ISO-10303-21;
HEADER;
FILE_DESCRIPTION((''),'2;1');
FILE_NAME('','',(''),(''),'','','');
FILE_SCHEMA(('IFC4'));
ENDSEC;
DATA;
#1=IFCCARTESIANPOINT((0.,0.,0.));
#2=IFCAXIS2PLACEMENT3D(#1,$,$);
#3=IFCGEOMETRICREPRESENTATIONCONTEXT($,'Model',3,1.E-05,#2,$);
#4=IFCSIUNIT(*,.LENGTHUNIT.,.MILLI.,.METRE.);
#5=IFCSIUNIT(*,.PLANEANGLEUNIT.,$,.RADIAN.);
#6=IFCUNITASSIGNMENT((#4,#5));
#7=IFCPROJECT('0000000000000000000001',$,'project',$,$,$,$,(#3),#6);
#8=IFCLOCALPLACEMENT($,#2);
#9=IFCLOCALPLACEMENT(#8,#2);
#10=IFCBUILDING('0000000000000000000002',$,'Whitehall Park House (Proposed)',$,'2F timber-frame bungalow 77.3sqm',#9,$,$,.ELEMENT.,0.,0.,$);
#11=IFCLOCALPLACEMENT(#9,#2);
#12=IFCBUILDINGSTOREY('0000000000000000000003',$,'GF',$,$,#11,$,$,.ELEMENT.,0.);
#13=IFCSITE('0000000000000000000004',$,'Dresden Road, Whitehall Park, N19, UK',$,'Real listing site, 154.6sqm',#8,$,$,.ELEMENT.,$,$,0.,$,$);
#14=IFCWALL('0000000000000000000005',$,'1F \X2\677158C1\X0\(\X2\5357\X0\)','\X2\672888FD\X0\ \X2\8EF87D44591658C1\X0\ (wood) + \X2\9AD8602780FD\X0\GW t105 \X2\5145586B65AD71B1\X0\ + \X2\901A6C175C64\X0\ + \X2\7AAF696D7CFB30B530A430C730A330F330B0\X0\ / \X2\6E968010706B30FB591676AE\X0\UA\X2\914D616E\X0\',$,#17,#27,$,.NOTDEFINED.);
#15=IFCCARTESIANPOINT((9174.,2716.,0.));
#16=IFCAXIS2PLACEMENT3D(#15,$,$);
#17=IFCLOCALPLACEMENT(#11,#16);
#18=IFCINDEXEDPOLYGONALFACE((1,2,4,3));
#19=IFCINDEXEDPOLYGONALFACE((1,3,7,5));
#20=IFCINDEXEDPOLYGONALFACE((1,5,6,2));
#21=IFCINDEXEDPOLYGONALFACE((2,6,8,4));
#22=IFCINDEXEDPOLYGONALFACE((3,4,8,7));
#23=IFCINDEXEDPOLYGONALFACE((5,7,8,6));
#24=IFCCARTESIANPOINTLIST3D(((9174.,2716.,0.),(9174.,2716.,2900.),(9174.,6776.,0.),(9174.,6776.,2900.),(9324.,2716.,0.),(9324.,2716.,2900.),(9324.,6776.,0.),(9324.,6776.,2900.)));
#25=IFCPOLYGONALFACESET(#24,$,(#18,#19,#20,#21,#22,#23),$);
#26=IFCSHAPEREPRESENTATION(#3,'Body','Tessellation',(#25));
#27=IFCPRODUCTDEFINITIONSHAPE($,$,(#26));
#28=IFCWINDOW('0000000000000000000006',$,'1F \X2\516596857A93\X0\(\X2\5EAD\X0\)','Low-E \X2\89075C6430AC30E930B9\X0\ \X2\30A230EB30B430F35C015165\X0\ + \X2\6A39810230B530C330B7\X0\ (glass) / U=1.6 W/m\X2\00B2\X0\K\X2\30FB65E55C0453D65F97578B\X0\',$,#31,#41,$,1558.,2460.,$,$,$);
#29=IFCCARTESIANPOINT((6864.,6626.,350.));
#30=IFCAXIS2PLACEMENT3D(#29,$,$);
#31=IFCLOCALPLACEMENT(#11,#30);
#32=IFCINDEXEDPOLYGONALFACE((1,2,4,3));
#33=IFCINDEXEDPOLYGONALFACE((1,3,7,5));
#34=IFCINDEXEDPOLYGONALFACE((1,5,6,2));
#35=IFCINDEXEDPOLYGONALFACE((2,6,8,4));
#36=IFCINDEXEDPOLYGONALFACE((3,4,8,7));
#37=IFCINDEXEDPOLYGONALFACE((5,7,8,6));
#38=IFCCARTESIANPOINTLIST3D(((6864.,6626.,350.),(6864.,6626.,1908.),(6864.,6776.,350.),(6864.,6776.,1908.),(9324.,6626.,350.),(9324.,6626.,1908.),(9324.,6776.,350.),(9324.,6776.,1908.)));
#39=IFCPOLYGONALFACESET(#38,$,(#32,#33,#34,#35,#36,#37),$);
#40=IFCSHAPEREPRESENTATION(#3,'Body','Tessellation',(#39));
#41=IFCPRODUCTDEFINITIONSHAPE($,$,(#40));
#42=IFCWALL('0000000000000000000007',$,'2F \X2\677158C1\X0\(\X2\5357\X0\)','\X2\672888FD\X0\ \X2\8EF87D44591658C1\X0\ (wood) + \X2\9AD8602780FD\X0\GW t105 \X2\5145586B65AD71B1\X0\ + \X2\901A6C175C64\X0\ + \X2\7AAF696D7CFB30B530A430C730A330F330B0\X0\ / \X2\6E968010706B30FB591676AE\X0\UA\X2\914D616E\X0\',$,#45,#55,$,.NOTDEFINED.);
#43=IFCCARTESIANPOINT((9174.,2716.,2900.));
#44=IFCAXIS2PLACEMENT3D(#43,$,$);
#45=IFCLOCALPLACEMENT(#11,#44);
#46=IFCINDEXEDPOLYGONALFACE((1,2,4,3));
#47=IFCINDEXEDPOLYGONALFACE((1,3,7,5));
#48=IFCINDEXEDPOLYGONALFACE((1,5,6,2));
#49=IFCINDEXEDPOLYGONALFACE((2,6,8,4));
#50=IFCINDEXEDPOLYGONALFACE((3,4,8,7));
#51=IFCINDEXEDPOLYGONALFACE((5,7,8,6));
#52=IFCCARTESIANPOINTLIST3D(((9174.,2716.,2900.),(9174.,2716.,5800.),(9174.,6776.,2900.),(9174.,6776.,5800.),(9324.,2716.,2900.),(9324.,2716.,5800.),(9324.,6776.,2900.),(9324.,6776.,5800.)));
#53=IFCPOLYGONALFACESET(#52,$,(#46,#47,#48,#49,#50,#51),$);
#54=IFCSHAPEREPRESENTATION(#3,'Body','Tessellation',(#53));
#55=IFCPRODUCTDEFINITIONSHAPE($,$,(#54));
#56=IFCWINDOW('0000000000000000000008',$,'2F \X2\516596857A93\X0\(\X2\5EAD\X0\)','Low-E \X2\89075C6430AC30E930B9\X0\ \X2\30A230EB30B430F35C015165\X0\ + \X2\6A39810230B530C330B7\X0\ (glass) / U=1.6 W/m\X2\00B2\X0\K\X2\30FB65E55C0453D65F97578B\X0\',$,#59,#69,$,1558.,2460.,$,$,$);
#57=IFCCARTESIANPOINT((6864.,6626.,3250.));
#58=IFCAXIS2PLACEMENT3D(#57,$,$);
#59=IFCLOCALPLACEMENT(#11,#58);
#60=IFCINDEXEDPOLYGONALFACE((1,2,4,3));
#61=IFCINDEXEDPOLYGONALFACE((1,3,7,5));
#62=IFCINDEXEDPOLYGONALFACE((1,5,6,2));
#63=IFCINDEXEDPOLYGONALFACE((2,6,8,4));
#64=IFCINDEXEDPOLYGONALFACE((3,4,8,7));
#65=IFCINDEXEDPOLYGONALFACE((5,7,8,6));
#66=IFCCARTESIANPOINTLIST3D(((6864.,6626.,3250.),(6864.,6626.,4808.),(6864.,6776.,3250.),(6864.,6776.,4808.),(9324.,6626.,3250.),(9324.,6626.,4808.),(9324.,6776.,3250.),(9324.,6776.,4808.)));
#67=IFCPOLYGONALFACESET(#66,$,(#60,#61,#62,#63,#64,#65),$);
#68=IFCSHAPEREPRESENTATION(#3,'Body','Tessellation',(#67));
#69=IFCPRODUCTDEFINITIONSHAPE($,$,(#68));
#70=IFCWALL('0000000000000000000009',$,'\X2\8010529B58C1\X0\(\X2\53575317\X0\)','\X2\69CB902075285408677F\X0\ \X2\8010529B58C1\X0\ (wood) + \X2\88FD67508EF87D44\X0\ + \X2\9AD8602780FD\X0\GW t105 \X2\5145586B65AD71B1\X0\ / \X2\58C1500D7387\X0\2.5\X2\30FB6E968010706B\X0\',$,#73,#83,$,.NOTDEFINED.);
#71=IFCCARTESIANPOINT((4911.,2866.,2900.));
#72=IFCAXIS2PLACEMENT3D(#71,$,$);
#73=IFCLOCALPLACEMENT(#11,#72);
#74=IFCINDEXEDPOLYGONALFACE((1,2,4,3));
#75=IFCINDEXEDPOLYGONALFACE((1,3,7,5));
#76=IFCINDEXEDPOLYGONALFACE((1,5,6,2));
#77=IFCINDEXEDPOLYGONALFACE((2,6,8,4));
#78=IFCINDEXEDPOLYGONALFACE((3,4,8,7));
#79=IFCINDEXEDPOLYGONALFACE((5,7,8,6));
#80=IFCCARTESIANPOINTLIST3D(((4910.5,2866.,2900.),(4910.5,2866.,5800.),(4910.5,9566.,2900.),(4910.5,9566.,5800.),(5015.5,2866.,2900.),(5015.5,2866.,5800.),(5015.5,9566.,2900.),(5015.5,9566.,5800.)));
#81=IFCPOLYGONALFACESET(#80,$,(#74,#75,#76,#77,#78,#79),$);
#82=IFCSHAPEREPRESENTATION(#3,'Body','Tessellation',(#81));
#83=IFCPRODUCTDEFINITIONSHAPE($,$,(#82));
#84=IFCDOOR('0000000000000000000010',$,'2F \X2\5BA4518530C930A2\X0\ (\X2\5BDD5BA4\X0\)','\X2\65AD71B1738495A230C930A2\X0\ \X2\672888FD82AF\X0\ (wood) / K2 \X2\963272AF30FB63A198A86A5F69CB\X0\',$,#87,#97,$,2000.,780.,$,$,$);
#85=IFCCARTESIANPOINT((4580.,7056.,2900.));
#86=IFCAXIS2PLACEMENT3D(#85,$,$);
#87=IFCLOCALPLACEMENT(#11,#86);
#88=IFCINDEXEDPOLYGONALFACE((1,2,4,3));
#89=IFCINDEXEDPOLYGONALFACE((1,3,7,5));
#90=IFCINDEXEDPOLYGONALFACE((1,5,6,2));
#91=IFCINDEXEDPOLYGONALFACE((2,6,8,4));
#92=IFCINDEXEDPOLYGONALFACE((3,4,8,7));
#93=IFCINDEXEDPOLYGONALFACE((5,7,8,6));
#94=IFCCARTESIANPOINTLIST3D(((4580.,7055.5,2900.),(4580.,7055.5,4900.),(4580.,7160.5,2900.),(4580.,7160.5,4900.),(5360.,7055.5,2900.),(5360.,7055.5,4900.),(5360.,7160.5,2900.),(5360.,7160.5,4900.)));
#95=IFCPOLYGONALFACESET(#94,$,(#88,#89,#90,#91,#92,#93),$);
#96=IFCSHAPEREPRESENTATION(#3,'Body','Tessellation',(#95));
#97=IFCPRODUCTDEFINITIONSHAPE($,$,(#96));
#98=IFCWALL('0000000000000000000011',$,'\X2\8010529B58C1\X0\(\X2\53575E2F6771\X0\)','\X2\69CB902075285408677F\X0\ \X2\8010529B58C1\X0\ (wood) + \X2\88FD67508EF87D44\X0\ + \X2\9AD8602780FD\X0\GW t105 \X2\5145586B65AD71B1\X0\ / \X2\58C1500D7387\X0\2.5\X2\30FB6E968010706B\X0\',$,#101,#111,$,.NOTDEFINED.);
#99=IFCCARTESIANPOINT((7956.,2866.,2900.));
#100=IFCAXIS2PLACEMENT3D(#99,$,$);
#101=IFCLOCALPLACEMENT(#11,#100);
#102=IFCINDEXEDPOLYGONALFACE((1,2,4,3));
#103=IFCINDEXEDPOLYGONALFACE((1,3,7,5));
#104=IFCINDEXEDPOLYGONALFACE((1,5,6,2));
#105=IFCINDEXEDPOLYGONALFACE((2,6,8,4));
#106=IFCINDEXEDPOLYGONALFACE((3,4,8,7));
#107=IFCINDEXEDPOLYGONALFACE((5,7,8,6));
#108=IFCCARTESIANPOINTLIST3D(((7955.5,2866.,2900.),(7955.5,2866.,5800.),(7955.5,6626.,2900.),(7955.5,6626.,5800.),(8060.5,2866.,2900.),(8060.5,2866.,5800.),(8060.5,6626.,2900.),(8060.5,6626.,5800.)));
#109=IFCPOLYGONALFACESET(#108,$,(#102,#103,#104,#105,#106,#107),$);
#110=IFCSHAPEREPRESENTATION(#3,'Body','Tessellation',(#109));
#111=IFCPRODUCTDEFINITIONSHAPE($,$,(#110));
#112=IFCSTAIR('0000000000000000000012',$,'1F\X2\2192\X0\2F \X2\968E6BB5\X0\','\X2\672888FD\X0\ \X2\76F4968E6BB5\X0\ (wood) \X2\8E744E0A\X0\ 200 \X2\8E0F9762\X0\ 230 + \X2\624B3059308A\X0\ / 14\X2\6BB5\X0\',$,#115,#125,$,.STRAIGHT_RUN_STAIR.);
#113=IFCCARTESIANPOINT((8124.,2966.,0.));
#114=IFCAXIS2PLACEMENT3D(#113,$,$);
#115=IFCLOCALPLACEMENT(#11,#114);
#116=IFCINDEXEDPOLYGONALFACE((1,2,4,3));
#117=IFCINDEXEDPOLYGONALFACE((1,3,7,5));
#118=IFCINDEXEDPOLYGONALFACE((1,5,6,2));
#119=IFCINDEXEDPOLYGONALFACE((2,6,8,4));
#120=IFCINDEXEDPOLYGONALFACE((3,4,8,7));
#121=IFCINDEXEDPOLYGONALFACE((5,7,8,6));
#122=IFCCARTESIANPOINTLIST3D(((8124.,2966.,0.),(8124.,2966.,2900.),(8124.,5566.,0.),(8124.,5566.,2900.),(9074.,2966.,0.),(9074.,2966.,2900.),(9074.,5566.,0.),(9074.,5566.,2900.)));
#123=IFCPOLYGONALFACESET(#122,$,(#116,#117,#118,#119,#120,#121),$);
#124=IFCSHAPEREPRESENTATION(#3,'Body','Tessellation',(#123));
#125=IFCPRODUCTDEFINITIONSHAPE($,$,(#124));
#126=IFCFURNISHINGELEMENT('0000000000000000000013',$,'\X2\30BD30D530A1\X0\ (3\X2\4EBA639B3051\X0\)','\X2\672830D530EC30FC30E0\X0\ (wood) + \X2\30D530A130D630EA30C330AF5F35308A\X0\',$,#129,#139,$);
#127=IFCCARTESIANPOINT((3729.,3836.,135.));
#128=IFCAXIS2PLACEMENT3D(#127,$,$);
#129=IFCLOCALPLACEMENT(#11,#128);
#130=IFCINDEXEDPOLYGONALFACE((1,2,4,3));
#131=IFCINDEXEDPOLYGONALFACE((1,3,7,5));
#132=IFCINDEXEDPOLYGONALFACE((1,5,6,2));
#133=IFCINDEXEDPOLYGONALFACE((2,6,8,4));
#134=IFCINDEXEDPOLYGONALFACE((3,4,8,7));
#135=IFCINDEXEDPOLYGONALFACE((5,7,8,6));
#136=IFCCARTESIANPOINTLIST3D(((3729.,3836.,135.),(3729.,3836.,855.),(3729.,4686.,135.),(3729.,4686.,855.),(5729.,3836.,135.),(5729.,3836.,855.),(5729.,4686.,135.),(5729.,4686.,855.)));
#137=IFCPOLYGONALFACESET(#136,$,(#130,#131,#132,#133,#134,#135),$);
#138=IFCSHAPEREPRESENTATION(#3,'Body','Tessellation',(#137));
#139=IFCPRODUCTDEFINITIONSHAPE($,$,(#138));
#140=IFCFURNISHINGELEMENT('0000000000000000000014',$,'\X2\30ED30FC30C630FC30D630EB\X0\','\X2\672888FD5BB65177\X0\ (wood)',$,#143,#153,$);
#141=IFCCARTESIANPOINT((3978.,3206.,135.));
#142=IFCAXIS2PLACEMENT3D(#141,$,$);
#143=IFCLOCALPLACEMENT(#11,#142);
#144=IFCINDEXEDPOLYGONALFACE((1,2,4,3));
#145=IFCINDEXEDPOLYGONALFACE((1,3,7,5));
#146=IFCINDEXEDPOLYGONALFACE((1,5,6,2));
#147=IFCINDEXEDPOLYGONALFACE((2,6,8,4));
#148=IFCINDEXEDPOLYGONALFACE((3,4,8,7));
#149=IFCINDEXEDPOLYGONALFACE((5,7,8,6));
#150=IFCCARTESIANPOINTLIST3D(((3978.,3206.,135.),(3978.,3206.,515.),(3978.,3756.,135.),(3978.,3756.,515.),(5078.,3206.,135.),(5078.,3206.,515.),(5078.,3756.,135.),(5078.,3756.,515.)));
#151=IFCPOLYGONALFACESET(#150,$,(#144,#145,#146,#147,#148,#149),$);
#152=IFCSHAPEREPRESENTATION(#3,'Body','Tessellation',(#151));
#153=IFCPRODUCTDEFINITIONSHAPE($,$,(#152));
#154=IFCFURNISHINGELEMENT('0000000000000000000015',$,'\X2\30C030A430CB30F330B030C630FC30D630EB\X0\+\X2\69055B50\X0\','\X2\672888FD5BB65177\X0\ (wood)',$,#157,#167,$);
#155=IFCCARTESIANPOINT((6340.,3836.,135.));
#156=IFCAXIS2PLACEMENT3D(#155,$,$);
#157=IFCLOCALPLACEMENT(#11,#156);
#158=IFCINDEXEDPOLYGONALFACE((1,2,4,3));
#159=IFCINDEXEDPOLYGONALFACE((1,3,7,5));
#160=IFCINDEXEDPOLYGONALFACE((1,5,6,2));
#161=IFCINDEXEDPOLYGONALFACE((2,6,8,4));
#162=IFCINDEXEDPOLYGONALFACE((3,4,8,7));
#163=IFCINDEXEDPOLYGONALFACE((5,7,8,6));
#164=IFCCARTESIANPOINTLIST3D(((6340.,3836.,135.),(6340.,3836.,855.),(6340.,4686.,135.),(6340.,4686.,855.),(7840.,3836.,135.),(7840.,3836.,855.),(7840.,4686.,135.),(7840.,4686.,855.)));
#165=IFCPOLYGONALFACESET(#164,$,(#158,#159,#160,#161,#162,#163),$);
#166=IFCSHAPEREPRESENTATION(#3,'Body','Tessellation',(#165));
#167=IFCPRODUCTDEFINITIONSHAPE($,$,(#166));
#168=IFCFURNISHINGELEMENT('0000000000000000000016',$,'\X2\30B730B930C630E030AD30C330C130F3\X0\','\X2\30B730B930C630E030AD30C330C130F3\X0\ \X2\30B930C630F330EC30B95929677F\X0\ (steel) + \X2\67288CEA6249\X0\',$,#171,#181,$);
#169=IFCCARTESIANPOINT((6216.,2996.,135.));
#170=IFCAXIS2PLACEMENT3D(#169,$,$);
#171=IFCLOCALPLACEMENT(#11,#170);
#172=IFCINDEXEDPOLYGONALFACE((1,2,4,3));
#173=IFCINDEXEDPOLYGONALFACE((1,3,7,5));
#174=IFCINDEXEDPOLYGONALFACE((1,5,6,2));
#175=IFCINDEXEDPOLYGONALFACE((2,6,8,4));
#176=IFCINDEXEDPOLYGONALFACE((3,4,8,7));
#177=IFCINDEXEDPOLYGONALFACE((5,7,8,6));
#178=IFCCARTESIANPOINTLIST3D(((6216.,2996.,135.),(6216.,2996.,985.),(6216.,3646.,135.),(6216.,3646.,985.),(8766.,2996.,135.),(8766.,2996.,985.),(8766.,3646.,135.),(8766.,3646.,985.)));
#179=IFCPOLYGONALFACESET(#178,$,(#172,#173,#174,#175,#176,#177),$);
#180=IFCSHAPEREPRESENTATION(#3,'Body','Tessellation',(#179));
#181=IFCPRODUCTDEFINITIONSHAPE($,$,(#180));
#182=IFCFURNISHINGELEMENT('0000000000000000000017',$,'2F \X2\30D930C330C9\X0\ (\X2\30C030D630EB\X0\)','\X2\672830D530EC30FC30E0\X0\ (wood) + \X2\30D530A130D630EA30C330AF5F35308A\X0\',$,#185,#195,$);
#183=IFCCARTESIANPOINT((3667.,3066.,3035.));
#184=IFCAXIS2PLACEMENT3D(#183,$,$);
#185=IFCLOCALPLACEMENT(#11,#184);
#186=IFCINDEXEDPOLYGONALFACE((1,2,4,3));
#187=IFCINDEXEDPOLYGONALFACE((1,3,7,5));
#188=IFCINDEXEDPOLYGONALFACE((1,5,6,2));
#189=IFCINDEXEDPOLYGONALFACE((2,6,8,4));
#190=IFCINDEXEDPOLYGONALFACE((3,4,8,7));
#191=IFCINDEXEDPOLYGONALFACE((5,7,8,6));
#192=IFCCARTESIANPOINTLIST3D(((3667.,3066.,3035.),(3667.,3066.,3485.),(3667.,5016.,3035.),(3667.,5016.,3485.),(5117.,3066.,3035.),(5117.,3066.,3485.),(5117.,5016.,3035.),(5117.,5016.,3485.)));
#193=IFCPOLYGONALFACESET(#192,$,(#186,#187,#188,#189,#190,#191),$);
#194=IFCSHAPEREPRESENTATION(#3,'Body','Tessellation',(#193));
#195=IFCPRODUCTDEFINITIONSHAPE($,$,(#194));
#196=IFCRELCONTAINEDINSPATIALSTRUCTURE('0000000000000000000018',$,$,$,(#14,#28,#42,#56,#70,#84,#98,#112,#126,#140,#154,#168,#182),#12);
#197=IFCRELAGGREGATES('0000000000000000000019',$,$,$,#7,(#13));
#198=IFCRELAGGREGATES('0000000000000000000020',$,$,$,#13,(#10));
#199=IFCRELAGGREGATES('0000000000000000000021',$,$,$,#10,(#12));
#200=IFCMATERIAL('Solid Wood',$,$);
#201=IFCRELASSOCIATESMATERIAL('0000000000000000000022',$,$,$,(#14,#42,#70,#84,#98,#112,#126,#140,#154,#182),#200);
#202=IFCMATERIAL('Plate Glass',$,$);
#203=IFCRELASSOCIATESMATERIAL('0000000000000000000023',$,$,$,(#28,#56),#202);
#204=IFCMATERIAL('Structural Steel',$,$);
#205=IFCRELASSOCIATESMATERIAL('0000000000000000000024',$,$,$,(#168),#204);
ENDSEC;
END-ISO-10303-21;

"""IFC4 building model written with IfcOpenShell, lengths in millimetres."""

from ifc_helpers import new_model, si_unit, frame, frame_2d, origin, place, context, project, spatial, rectangle, extrude, material, element, fill, save


model = new_model("IFC4")

# Units and contexts
model_context = context("Model", 3, precision=1e-05, world=origin())
ifc_project = project(units=[si_unit("LENGTHUNIT", "METRE", prefix="MILLI"), si_unit("PLANEANGLEUNIT", "RADIAN")], contexts=[model_context])

# Site, building, storey
site_placement = place(None, origin())
site = spatial("IfcSite", under=ifc_project, at=site_placement, Name="Dresden Road, Whitehall Park, N19, UK", ObjectType="Real listing site, 154.6sqm", CompositionType="ELEMENT", RefElevation=0.0)
building_placement = place(site_placement, origin())
building = spatial("IfcBuilding", under=site, at=building_placement, Name="Whitehall Park House (Proposed)", ObjectType="2F timber-frame bungalow 77.3sqm", CompositionType="ELEMENT", ElevationOfRefHeight=0.0, ElevationOfTerrain=0.0)
storey_placement = place(building_placement, origin())
storey = spatial("IfcBuildingStorey", under=building, at=storey_placement, Name="GF", CompositionType="ELEMENT", Elevation=0.0)

# Wall, opening, window
ifc_material_1 = material(Name="Solid Wood")
wall_1_placement = place(storey_placement, frame((9174.0, 2716.0, 0.0)))
wall_1 = element("IfcWall", 1, at=wall_1_placement, inside=storey, material=ifc_material_1, Name="1F 東壁(南)", Description="木製 軸組外壁 (wood) + 高性能GW t105 充填断熱 + 通気層 + 窯業系サイディング / 準耐火・外皮UA配慮", PredefinedType="NOTDEFINED", context=model_context, shape_type="SweptSolid", body=[
    extrude(rectangle(XDim=150.0, YDim=4060.0, at=frame_2d((75.0, 2030.0))), frame((9174.0, 2716.0, 0.0)), (0.0, 0.0, 1.0), 2900.0),
])
opening_1_placement = place(storey_placement, frame((6864.0, 6626.0, 350.0)))
opening_1 = element("IfcOpeningElement", 2, at=opening_1_placement, cuts=wall_1, PredefinedType="NOTDEFINED", context=model_context, shape_type="SweptSolid", body=[
    extrude(rectangle(XDim=2460.0, YDim=150.0, at=frame_2d((1230.0, 75.0))), frame((6864.0, 6626.0, 350.0)), (0.0, 0.0, 1.0), 1558.0),
])
ifc_material_2 = material(Name="Plate Glass")
window_1_placement = place(storey_placement, frame((6864.0, 6626.0, 350.0)))
window_1 = element("IfcWindow", 3, at=window_1_placement, inside=storey, material=ifc_material_2, Name="1F 入隅窓(庭)", Description="Low-E 複層ガラス アルゴン封入 + 樹脂サッシ (glass) / U=1.6 W/m²K・日射取得型", OverallHeight=1558.0, OverallWidth=2460.0, context=model_context, shape_type="SweptSolid", body=[
    extrude(rectangle(XDim=2460.0, YDim=150.0, at=frame_2d((1230.0, 75.0))), frame((6864.0, 6626.0, 350.0)), (0.0, 0.0, 1.0), 1558.0),
])
fill(opening_1, window_1)

# Wall, opening, window
wall_2_placement = place(storey_placement, frame((9174.0, 2716.0, 2900.0)))
wall_2 = element("IfcWall", 4, at=wall_2_placement, inside=storey, material=ifc_material_1, Name="2F 東壁(南)", Description="木製 軸組外壁 (wood) + 高性能GW t105 充填断熱 + 通気層 + 窯業系サイディング / 準耐火・外皮UA配慮", PredefinedType="NOTDEFINED", context=model_context, shape_type="SweptSolid", body=[
    extrude(rectangle(XDim=150.0, YDim=4060.0, at=frame_2d((75.0, 2030.0))), frame((9174.0, 2716.0, 2900.0)), (0.0, 0.0, 1.0), 2900.0),
])
opening_2_placement = place(storey_placement, frame((6864.0, 6626.0, 3250.0)))
opening_2 = element("IfcOpeningElement", 5, at=opening_2_placement, cuts=wall_2, PredefinedType="NOTDEFINED", context=model_context, shape_type="SweptSolid", body=[
    extrude(rectangle(XDim=2460.0, YDim=150.0, at=frame_2d((1230.0, 75.0))), frame((6864.0, 6626.0, 3250.0)), (0.0, 0.0, 1.0), 1558.0),
])
window_2_placement = place(storey_placement, frame((6864.0, 6626.0, 3250.0)))
window_2 = element("IfcWindow", 6, at=window_2_placement, inside=storey, material=ifc_material_2, Name="2F 入隅窓(庭)", Description="Low-E 複層ガラス アルゴン封入 + 樹脂サッシ (glass) / U=1.6 W/m²K・日射取得型", OverallHeight=1558.0, OverallWidth=2460.0, context=model_context, shape_type="SweptSolid", body=[
    extrude(rectangle(XDim=2460.0, YDim=150.0, at=frame_2d((1230.0, 75.0))), frame((6864.0, 6626.0, 3250.0)), (0.0, 0.0, 1.0), 1558.0),
])
fill(opening_2, window_2)

# Wall, opening, door
wall_3_placement = place(storey_placement, frame((4911.0, 2866.0, 2900.0)))
wall_3 = element("IfcWall", 7, at=wall_3_placement, inside=storey, material=ifc_material_1, Name="耐力壁(南北)", Description="構造用合板 耐力壁 (wood) + 製材軸組 + 高性能GW t105 充填断熱 / 壁倍率2.5・準耐火", PredefinedType="NOTDEFINED", context=model_context, shape_type="SweptSolid", body=[
    extrude(rectangle(XDim=105.0, YDim=6700.0, at=frame_2d((52.0, 3350.0))), frame((4911.0, 2866.0, 2900.0)), (0.0, 0.0, 1.0), 2900.0),
])
opening_3_placement = place(storey_placement, frame((4580.0, 7056.0, 2900.0)))
opening_3 = element("IfcOpeningElement", 8, at=opening_3_placement, cuts=wall_3, PredefinedType="NOTDEFINED", context=model_context, shape_type="SweptSolid", body=[
    extrude(rectangle(XDim=780.0, YDim=105.0, at=frame_2d((390.0, 52.0))), frame((4580.0, 7056.0, 2900.0)), (0.0, 0.0, 1.0), 2000.0),
])
door_1_placement = place(storey_placement, frame((4580.0, 7056.0, 2900.0)))
door_1 = element("IfcDoor", 9, at=door_1_placement, inside=storey, material=ifc_material_1, Name="2F 室内ドア (寝室)", Description="断熱玄関ドア 木製芯 (wood) / K2 防犯・採風機構", OverallHeight=2000.0, OverallWidth=780.0, context=model_context, shape_type="SweptSolid", body=[
    extrude(rectangle(XDim=780.0, YDim=105.0, at=frame_2d((390.0, 52.0))), frame((4580.0, 7056.0, 2900.0)), (0.0, 0.0, 1.0), 2000.0),
])
fill(opening_3, door_1)

# Wall
wall_4_placement = place(storey_placement, frame((7956.0, 2866.0, 2900.0)))
element("IfcWall", 10, at=wall_4_placement, inside=storey, material=ifc_material_1, Name="耐力壁(南帯東)", Description="構造用合板 耐力壁 (wood) + 製材軸組 + 高性能GW t105 充填断熱 / 壁倍率2.5・準耐火", PredefinedType="NOTDEFINED", context=model_context, shape_type="SweptSolid", body=[
    extrude(rectangle(XDim=105.0, YDim=3760.0, at=frame_2d((52.0, 1880.0))), frame((7956.0, 2866.0, 2900.0)), (0.0, 0.0, 1.0), 2900.0),
])

# Stair
stair_placement = place(storey_placement, frame((8124.0, 2966.0, 0.0)))
element("IfcStair", 11, at=stair_placement, inside=storey, material=ifc_material_1, Name="1F→2F 階段", Description="木製 直階段 (wood) 蹴上 200 踏面 230 + 手すり / 14段", PredefinedType="STRAIGHT_RUN_STAIR", context=model_context, shape_type="SweptSolid", body=[
    extrude(rectangle(XDim=950.0, YDim=2600.0, at=frame_2d((475.0, 1300.0))), frame((8124.0, 2966.0, 0.0)), (0.0, 0.0, 1.0), 2900.0),
])

# Furnishing elements
furnishing_1_placement = place(storey_placement, frame((3729.0, 3836.0, 135.0)))
element("IfcFurnishingElement", 12, at=furnishing_1_placement, inside=storey, material=ifc_material_1, Name="ソファ (3人掛け)", Description="木フレーム (wood) + ファブリック張り", context=model_context, shape_type="SweptSolid", body=[
    extrude(rectangle(XDim=2000.0, YDim=850.0, at=frame_2d((1000.0, 425.0))), frame((3729.0, 3836.0, 135.0)), (0.0, 0.0, 1.0), 720.0),
])
furnishing_2_placement = place(storey_placement, frame((3978.0, 3206.0, 135.0)))
element("IfcFurnishingElement", 13, at=furnishing_2_placement, inside=storey, material=ifc_material_1, Name="ローテーブル", Description="木製家具 (wood)", context=model_context, shape_type="SweptSolid", body=[
    extrude(rectangle(XDim=1100.0, YDim=550.0, at=frame_2d((550.0, 275.0))), frame((3978.0, 3206.0, 135.0)), (0.0, 0.0, 1.0), 380.0),
])
furnishing_3_placement = place(storey_placement, frame((6340.0, 3836.0, 135.0)))
element("IfcFurnishingElement", 14, at=furnishing_3_placement, inside=storey, material=ifc_material_1, Name="ダイニングテーブル+椅子", Description="木製家具 (wood)", context=model_context, shape_type="SweptSolid", body=[
    extrude(rectangle(XDim=1500.0, YDim=850.0, at=frame_2d((750.0, 425.0))), frame((6340.0, 3836.0, 135.0)), (0.0, 0.0, 1.0), 720.0),
])
ifc_material_3 = material(Name="Structural Steel")
furnishing_4_placement = place(storey_placement, frame((6216.0, 2996.0, 135.0)))
element("IfcFurnishingElement", 15, at=furnishing_4_placement, inside=storey, material=ifc_material_3, Name="システムキッチン", Description="システムキッチン ステンレス天板 (steel) + 木質扉", context=model_context, shape_type="SweptSolid", body=[
    extrude(rectangle(XDim=2550.0, YDim=650.0, at=frame_2d((1275.0, 325.0))), frame((6216.0, 2996.0, 135.0)), (0.0, 0.0, 1.0), 850.0),
])
furnishing_5_placement = place(storey_placement, frame((3667.0, 3066.0, 3035.0)))
element("IfcFurnishingElement", 16, at=furnishing_5_placement, inside=storey, material=ifc_material_1, Name="2F ベッド (ダブル)", Description="木フレーム (wood) + ファブリック張り", context=model_context, shape_type="SweptSolid", body=[
    extrude(rectangle(XDim=1450.0, YDim=1950.0, at=frame_2d((725.0, 975.0))), frame((3667.0, 3066.0, 3035.0)), (0.0, 0.0, 1.0), 450.0),
])

save(model, "model.ifc")
